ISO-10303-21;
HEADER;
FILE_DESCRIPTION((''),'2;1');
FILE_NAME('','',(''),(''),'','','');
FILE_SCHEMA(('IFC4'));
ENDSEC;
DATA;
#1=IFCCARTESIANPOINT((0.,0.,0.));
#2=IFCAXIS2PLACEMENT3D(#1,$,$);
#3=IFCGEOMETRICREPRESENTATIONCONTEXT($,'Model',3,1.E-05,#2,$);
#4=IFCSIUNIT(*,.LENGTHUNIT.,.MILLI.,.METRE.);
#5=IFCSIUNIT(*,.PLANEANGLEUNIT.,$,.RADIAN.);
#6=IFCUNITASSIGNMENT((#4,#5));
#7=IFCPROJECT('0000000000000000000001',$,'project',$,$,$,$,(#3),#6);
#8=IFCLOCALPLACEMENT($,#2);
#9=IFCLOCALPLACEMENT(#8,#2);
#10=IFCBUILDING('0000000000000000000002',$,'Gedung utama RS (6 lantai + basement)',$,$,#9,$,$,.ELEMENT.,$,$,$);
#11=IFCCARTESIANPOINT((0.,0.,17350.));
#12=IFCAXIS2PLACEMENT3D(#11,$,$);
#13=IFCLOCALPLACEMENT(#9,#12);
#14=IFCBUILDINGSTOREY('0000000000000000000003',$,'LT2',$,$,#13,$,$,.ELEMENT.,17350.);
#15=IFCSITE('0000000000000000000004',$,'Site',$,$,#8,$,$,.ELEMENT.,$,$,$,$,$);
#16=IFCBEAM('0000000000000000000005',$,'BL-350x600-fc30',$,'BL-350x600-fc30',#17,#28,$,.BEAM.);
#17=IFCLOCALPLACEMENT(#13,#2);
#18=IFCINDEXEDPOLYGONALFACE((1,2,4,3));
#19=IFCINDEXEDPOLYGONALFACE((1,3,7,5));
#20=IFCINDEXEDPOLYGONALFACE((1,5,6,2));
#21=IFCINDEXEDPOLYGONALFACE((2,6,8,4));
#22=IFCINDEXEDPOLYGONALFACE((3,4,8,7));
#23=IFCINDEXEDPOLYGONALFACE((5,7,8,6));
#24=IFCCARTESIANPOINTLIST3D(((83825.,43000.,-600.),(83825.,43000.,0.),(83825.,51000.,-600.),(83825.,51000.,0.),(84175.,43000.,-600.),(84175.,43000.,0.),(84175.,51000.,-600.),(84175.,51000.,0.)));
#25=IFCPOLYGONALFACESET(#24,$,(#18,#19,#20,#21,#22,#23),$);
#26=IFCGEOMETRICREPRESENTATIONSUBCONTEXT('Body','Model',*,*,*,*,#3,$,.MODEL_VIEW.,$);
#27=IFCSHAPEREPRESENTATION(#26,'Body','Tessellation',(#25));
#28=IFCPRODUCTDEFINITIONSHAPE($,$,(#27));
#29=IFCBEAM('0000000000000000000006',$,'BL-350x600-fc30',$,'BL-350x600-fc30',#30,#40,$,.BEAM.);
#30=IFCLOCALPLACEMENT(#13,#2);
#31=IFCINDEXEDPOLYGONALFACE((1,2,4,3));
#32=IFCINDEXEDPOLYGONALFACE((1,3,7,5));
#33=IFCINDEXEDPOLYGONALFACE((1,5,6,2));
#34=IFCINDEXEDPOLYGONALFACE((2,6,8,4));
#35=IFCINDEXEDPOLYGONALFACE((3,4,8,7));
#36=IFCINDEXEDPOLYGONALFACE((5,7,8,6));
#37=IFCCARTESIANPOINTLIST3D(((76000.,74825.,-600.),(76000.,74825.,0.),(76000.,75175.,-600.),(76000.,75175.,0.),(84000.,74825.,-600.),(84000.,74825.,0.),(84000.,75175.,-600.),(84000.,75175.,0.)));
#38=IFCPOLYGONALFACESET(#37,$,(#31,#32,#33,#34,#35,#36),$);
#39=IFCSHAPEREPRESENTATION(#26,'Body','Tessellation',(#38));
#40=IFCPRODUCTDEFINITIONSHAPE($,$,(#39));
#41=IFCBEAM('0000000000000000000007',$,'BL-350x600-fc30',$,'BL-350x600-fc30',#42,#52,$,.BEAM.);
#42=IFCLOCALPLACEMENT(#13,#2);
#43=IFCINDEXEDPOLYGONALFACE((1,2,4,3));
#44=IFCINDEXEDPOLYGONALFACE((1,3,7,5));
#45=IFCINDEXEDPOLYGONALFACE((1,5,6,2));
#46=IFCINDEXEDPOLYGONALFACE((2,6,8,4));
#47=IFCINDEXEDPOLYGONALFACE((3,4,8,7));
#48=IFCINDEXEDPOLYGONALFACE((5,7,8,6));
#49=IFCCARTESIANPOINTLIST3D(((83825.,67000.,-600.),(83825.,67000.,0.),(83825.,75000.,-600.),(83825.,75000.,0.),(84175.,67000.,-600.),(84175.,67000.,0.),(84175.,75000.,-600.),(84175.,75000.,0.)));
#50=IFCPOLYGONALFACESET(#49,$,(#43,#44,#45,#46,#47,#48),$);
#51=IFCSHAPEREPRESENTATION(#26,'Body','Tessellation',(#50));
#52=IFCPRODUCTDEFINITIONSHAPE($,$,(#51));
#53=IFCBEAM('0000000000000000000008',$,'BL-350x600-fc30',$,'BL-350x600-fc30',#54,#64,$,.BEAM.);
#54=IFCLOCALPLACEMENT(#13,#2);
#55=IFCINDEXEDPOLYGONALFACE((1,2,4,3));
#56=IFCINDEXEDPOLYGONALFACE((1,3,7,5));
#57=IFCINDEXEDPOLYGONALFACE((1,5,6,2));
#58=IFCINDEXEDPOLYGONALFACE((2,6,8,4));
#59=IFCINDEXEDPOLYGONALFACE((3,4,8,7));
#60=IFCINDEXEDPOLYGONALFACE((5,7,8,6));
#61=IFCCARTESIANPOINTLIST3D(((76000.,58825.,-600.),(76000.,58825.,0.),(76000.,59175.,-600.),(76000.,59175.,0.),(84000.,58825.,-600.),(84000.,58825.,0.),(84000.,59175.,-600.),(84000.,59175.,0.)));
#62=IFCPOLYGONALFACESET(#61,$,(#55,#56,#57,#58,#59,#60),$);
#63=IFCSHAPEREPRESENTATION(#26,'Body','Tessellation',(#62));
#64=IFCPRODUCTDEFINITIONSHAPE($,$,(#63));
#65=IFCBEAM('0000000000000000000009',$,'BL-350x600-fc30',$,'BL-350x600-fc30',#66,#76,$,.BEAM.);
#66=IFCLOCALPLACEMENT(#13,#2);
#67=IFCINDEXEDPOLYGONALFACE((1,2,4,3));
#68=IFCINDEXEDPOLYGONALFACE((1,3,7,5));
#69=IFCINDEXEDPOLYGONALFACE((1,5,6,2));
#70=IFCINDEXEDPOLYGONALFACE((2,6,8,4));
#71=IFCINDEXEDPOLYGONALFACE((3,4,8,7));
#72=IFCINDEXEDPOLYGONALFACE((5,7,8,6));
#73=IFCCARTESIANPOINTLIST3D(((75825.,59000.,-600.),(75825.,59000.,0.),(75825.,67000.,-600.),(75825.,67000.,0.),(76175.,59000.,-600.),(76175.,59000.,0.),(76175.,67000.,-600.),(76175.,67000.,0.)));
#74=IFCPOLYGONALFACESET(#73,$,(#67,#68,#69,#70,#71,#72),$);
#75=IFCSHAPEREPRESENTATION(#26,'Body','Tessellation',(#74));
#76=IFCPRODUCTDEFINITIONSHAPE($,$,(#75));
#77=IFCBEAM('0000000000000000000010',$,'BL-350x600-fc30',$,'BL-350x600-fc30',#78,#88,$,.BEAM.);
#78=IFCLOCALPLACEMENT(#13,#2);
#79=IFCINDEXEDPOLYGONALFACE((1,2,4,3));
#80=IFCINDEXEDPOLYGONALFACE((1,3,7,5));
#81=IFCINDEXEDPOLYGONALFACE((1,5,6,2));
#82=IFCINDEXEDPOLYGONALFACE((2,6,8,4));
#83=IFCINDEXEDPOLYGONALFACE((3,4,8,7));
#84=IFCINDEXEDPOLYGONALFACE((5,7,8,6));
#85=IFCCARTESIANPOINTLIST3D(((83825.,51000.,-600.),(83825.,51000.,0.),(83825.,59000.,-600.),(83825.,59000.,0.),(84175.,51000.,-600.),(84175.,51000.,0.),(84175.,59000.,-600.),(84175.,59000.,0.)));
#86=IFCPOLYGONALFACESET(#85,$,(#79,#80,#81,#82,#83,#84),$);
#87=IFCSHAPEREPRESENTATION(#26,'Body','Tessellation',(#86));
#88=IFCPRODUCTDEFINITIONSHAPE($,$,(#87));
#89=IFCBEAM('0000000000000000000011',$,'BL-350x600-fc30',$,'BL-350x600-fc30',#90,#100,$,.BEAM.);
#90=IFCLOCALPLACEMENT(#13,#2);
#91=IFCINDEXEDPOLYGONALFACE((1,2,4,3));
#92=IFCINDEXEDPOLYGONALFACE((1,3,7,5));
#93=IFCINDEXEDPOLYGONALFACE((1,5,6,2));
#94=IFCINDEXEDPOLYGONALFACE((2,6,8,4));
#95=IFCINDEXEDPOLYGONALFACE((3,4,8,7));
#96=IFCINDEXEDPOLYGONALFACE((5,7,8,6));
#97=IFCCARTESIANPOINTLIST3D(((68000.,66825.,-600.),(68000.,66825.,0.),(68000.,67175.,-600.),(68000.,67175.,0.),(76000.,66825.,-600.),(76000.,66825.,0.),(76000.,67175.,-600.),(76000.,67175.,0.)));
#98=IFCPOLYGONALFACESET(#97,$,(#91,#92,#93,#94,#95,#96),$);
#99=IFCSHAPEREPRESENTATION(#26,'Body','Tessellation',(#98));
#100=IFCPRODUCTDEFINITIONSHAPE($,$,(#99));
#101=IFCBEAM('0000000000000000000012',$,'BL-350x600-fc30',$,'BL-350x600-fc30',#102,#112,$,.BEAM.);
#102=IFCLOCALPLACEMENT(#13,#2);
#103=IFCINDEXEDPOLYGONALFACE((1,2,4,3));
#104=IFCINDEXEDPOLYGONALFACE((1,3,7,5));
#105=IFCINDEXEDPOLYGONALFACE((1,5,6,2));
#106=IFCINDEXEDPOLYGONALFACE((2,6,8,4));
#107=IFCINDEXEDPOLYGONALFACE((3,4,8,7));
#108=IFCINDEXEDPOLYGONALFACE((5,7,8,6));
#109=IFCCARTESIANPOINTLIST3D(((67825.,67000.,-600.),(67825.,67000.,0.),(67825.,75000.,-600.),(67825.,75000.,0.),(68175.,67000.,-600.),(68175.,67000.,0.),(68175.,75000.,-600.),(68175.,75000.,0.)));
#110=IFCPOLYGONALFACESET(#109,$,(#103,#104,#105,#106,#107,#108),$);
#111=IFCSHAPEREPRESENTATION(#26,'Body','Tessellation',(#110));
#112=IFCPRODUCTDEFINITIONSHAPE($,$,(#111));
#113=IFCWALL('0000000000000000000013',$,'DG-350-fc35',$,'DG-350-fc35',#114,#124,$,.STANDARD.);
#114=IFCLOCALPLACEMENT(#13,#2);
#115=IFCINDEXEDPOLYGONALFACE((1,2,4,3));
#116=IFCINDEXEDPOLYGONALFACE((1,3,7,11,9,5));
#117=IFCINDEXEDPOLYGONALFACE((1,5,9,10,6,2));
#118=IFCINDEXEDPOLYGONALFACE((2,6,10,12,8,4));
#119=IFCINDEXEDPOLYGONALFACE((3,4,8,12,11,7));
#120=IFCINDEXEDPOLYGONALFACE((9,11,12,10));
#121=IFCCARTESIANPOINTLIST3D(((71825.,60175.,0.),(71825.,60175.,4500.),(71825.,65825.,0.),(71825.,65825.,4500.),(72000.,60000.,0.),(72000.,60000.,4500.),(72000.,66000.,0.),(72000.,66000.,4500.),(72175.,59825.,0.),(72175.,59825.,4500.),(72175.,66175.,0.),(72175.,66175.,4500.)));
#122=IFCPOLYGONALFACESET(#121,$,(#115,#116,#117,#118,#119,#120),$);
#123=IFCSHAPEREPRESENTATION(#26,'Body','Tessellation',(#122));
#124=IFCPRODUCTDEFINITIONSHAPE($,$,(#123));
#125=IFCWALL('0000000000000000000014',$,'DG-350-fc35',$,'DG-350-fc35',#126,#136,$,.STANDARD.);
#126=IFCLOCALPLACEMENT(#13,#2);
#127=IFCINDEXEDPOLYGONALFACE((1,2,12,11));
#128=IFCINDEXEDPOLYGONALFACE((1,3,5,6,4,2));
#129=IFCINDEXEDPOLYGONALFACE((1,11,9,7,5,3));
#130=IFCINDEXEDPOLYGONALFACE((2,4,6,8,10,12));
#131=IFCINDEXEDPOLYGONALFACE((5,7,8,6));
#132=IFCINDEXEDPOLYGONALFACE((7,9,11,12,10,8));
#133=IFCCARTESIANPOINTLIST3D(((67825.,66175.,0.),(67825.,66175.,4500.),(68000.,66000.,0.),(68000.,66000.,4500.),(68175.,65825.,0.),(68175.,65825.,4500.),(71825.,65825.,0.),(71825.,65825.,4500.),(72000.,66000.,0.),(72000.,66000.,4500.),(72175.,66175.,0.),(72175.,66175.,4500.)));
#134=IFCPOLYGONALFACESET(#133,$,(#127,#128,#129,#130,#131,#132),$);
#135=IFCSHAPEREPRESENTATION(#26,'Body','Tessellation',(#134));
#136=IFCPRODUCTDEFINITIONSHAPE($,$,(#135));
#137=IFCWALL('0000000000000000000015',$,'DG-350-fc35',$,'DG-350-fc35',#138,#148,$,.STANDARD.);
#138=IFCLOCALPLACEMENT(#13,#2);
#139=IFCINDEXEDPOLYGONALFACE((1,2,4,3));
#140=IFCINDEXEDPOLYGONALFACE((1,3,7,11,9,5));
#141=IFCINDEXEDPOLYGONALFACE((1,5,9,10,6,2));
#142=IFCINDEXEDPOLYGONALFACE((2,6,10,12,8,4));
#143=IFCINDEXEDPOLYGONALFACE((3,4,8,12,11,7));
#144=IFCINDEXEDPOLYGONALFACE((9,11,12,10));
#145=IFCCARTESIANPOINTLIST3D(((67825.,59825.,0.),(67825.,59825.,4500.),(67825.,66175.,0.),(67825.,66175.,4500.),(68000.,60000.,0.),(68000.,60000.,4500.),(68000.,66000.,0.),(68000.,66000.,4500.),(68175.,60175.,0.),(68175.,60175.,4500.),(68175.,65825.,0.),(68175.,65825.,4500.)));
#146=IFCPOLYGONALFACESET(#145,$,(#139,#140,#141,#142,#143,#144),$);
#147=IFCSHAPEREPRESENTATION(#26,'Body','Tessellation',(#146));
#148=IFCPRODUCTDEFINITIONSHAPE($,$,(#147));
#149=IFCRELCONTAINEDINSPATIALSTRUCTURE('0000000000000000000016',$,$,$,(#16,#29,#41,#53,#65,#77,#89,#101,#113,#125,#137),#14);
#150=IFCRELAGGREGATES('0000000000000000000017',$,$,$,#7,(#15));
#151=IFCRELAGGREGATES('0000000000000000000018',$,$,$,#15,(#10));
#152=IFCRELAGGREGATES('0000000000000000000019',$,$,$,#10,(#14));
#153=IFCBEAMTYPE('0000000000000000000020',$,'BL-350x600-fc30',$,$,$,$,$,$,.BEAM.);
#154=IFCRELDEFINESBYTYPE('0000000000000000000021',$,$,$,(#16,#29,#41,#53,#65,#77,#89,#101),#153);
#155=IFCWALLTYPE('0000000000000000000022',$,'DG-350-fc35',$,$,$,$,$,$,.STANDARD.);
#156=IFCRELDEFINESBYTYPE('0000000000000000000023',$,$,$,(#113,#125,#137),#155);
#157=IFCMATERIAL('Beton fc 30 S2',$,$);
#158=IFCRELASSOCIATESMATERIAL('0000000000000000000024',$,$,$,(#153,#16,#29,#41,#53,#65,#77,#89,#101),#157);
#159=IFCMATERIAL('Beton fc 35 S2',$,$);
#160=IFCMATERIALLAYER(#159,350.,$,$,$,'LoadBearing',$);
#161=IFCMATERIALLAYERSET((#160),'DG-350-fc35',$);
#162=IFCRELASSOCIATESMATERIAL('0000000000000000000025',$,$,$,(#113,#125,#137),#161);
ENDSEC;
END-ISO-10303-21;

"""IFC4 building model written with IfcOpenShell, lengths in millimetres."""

from ifc_helpers import new_model, si_unit, frame, origin, origin_2d, place, context, subcontext, project, spatial, polyline, rectangle, outline, extrude, material, layer, layer_set, layer_usage, material_profile, profile_set, profile_usage, type_object, element, save


model = new_model("IFC4")

# Units and contexts
model_context = context("Model", 3, precision=1e-05, world=origin())
body_context = subcontext(model_context, "Body", "Model", "MODEL_VIEW")
ifc_project = project(units=[si_unit("LENGTHUNIT", "METRE", prefix="MILLI"), si_unit("PLANEANGLEUNIT", "RADIAN")], contexts=[model_context])

# Site, building, storey
site_placement = place(None, origin())
site = spatial("IfcSite", under=ifc_project, at=site_placement, Name="Site", CompositionType="ELEMENT")
building_placement = place(site_placement, origin())
building = spatial("IfcBuilding", under=site, at=building_placement, Name="Gedung utama RS (6 lantai + basement)", CompositionType="ELEMENT")
storey_placement = place(building_placement, frame((0.0, 0.0, 17350.0)))
storey = spatial("IfcBuildingStorey", under=building, at=storey_placement, Name="LT2", CompositionType="ELEMENT", Elevation=17350.0)

# Beams
ifc_material_1 = material(Name="Beton fc 30 S2")
ifc_material_profile_1 = material_profile(ifc_material_1, rectangle(XDim=350.0, YDim=600.0, at=origin_2d()), Name="BL-350x600-fc30")
ifc_profile_set_1 = profile_set([ifc_material_profile_1], Name="BL-350x600-fc30")
ifc_profile_usage_1 = profile_usage(ifc_profile_set_1, cardinal=8)
beam_type = type_object("IfcBeamType", Name="BL-350x600-fc30", PredefinedType="BEAM", material=ifc_profile_set_1)
for number, where, name in (
    (1, (84000.0, 43000.0, -300.0), "BL-350x600-fc30"),
):
    element("IfcBeam", number, at=place(storey_placement, frame(where)), inside=storey, type_object=beam_type, material=ifc_profile_usage_1, Name=name, ObjectType="BL-350x600-fc30", PredefinedType="BEAM", context=body_context, shape_type="SweptSolid", body=[
        extrude(rectangle(XDim=350.0, YDim=600.0, at=origin_2d()), frame((0.0, 0.0, 0.0), z_axis=(0.0, 1.0, 0.0), x_axis=(-1.0, 0.0, 0.0)), (0.0, 0.0, 1.0), 8000.0),
    ])
beam_1_placement = place(storey_placement, frame((76000.0, 75000.0, -300.0)))
element("IfcBeam", 2, at=beam_1_placement, inside=storey, type_object=beam_type, material=ifc_profile_usage_1, Name="BL-350x600-fc30", ObjectType="BL-350x600-fc30", PredefinedType="BEAM", context=body_context, shape_type="SweptSolid", body=[
    extrude(rectangle(XDim=350.0, YDim=600.0, at=origin_2d()), frame((0.0, 0.0, 0.0), z_axis=(1.0, 0.0, 0.0), x_axis=(0.0, 1.0, 0.0)), (0.0, 0.0, 1.0), 8000.0),
])
beam_2_placement = place(storey_placement, frame((84000.0, 67000.0, -300.0)))
element("IfcBeam", 3, at=beam_2_placement, inside=storey, type_object=beam_type, material=ifc_profile_usage_1, Name="BL-350x600-fc30", ObjectType="BL-350x600-fc30", PredefinedType="BEAM", context=body_context, shape_type="SweptSolid", body=[
    extrude(rectangle(XDim=350.0, YDim=600.0, at=origin_2d()), frame((0.0, 0.0, 0.0), z_axis=(0.0, 1.0, 0.0), x_axis=(-1.0, 0.0, 0.0)), (0.0, 0.0, 1.0), 8000.0),
])
beam_3_placement = place(storey_placement, frame((76000.0, 59000.0, -300.0)))
element("IfcBeam", 4, at=beam_3_placement, inside=storey, type_object=beam_type, material=ifc_profile_usage_1, Name="BL-350x600-fc30", ObjectType="BL-350x600-fc30", PredefinedType="BEAM", context=body_context, shape_type="SweptSolid", body=[
    extrude(rectangle(XDim=350.0, YDim=600.0, at=origin_2d()), frame((0.0, 0.0, 0.0), z_axis=(1.0, 0.0, 0.0), x_axis=(0.0, 1.0, 0.0)), (0.0, 0.0, 1.0), 8000.0),
])
for number, where, name in (
    (5, (76000.0, 59000.0, -300.0), "BL-350x600-fc30"),
    (6, (84000.0, 51000.0, -300.0), "BL-350x600-fc30"),
):
    element("IfcBeam", number, at=place(storey_placement, frame(where)), inside=storey, type_object=beam_type, material=ifc_profile_usage_1, Name=name, ObjectType="BL-350x600-fc30", PredefinedType="BEAM", context=body_context, shape_type="SweptSolid", body=[
        extrude(rectangle(XDim=350.0, YDim=600.0, at=origin_2d()), frame((0.0, 0.0, 0.0), z_axis=(0.0, 1.0, 0.0), x_axis=(-1.0, 0.0, 0.0)), (0.0, 0.0, 1.0), 8000.0),
    ])
beam_4_placement = place(storey_placement, frame((68000.0, 67000.0, -300.0)))
element("IfcBeam", 7, at=beam_4_placement, inside=storey, type_object=beam_type, material=ifc_profile_usage_1, Name="BL-350x600-fc30", ObjectType="BL-350x600-fc30", PredefinedType="BEAM", context=body_context, shape_type="SweptSolid", body=[
    extrude(rectangle(XDim=350.0, YDim=600.0, at=origin_2d()), frame((0.0, 0.0, 0.0), z_axis=(1.0, 0.0, 0.0), x_axis=(0.0, 1.0, 0.0)), (0.0, 0.0, 1.0), 8000.0),
])
beam_5_placement = place(storey_placement, frame((68000.0, 67000.0, -300.0)))
element("IfcBeam", 8, at=beam_5_placement, inside=storey, type_object=beam_type, material=ifc_profile_usage_1, Name="BL-350x600-fc30", ObjectType="BL-350x600-fc30", PredefinedType="BEAM", context=body_context, shape_type="SweptSolid", body=[
    extrude(rectangle(XDim=350.0, YDim=600.0, at=origin_2d()), frame((0.0, 0.0, 0.0), z_axis=(0.0, 1.0, 0.0), x_axis=(-1.0, 0.0, 0.0)), (0.0, 0.0, 1.0), 8000.0),
])

# Walls
ifc_material_2 = material(Name="Beton fc 35 S2")
ifc_layer = layer(ifc_material_2, 350.0, Category="LoadBearing")
ifc_layer_set = layer_set([ifc_layer], Name="DG-350-fc35")
ifc_layer_usage = layer_usage(ifc_layer_set, "AXIS2", "NEGATIVE", 175.0)
wall_type = type_object("IfcWallType", Name="DG-350-fc35", PredefinedType="STANDARD")
wall_1_placement = place(storey_placement, frame((72000.0, 60000.0, 0.0), z_axis=(0.0, 0.0, 1.0), x_axis=(0.0, 1.0, 0.0)))
element("IfcWall", 9, at=wall_1_placement, inside=storey, type_object=wall_type, material=ifc_layer_usage, Name="DG-350-fc35", ObjectType="DG-350-fc35", PredefinedType="STANDARD", context=body_context, shape_type="SweptSolid", body=[
    extrude(outline(polyline([(-175.0, -175.0), (0.0, 0.0), (175.0, 175.0), (5825.0, 175.0), (6000.0, 0.0), (6175.0, -175.0), (-175.0, -175.0)])), origin(), (0.0, 0.0, 1.0), 4500.0),
])
wall_2_placement = place(storey_placement, frame((72000.0, 66000.0, 0.0), z_axis=(0.0, 0.0, 1.0), x_axis=(-1.0, 0.0, 0.0)))
element("IfcWall", 10, at=wall_2_placement, inside=storey, type_object=wall_type, material=ifc_layer_usage, Name="DG-350-fc35", ObjectType="DG-350-fc35", PredefinedType="STANDARD", context=body_context, shape_type="SweptSolid", body=[
    extrude(outline(polyline([(-175.0, -175.0), (0.0, 0.0), (175.0, 175.0), (3825.0, 175.0), (4000.0, 0.0), (4175.0, -175.0), (-175.0, -175.0)])), origin(), (0.0, 0.0, 1.0), 4500.0),
])
wall_3_placement = place(storey_placement, frame((68000.0, 66000.0, 0.0), z_axis=(0.0, 0.0, 1.0), x_axis=(0.0, -1.0, 0.0)))
element("IfcWall", 11, at=wall_3_placement, inside=storey, type_object=wall_type, material=ifc_layer_usage, Name="DG-350-fc35", ObjectType="DG-350-fc35", PredefinedType="STANDARD", context=body_context, shape_type="SweptSolid", body=[
    extrude(outline(polyline([(-175.0, -175.0), (0.0, 0.0), (175.0, 175.0), (5825.0, 175.0), (6000.0, 0.0), (6175.0, -175.0), (-175.0, -175.0)])), origin(), (0.0, 0.0, 1.0), 4500.0),
])

save(model, "model.ifc")
